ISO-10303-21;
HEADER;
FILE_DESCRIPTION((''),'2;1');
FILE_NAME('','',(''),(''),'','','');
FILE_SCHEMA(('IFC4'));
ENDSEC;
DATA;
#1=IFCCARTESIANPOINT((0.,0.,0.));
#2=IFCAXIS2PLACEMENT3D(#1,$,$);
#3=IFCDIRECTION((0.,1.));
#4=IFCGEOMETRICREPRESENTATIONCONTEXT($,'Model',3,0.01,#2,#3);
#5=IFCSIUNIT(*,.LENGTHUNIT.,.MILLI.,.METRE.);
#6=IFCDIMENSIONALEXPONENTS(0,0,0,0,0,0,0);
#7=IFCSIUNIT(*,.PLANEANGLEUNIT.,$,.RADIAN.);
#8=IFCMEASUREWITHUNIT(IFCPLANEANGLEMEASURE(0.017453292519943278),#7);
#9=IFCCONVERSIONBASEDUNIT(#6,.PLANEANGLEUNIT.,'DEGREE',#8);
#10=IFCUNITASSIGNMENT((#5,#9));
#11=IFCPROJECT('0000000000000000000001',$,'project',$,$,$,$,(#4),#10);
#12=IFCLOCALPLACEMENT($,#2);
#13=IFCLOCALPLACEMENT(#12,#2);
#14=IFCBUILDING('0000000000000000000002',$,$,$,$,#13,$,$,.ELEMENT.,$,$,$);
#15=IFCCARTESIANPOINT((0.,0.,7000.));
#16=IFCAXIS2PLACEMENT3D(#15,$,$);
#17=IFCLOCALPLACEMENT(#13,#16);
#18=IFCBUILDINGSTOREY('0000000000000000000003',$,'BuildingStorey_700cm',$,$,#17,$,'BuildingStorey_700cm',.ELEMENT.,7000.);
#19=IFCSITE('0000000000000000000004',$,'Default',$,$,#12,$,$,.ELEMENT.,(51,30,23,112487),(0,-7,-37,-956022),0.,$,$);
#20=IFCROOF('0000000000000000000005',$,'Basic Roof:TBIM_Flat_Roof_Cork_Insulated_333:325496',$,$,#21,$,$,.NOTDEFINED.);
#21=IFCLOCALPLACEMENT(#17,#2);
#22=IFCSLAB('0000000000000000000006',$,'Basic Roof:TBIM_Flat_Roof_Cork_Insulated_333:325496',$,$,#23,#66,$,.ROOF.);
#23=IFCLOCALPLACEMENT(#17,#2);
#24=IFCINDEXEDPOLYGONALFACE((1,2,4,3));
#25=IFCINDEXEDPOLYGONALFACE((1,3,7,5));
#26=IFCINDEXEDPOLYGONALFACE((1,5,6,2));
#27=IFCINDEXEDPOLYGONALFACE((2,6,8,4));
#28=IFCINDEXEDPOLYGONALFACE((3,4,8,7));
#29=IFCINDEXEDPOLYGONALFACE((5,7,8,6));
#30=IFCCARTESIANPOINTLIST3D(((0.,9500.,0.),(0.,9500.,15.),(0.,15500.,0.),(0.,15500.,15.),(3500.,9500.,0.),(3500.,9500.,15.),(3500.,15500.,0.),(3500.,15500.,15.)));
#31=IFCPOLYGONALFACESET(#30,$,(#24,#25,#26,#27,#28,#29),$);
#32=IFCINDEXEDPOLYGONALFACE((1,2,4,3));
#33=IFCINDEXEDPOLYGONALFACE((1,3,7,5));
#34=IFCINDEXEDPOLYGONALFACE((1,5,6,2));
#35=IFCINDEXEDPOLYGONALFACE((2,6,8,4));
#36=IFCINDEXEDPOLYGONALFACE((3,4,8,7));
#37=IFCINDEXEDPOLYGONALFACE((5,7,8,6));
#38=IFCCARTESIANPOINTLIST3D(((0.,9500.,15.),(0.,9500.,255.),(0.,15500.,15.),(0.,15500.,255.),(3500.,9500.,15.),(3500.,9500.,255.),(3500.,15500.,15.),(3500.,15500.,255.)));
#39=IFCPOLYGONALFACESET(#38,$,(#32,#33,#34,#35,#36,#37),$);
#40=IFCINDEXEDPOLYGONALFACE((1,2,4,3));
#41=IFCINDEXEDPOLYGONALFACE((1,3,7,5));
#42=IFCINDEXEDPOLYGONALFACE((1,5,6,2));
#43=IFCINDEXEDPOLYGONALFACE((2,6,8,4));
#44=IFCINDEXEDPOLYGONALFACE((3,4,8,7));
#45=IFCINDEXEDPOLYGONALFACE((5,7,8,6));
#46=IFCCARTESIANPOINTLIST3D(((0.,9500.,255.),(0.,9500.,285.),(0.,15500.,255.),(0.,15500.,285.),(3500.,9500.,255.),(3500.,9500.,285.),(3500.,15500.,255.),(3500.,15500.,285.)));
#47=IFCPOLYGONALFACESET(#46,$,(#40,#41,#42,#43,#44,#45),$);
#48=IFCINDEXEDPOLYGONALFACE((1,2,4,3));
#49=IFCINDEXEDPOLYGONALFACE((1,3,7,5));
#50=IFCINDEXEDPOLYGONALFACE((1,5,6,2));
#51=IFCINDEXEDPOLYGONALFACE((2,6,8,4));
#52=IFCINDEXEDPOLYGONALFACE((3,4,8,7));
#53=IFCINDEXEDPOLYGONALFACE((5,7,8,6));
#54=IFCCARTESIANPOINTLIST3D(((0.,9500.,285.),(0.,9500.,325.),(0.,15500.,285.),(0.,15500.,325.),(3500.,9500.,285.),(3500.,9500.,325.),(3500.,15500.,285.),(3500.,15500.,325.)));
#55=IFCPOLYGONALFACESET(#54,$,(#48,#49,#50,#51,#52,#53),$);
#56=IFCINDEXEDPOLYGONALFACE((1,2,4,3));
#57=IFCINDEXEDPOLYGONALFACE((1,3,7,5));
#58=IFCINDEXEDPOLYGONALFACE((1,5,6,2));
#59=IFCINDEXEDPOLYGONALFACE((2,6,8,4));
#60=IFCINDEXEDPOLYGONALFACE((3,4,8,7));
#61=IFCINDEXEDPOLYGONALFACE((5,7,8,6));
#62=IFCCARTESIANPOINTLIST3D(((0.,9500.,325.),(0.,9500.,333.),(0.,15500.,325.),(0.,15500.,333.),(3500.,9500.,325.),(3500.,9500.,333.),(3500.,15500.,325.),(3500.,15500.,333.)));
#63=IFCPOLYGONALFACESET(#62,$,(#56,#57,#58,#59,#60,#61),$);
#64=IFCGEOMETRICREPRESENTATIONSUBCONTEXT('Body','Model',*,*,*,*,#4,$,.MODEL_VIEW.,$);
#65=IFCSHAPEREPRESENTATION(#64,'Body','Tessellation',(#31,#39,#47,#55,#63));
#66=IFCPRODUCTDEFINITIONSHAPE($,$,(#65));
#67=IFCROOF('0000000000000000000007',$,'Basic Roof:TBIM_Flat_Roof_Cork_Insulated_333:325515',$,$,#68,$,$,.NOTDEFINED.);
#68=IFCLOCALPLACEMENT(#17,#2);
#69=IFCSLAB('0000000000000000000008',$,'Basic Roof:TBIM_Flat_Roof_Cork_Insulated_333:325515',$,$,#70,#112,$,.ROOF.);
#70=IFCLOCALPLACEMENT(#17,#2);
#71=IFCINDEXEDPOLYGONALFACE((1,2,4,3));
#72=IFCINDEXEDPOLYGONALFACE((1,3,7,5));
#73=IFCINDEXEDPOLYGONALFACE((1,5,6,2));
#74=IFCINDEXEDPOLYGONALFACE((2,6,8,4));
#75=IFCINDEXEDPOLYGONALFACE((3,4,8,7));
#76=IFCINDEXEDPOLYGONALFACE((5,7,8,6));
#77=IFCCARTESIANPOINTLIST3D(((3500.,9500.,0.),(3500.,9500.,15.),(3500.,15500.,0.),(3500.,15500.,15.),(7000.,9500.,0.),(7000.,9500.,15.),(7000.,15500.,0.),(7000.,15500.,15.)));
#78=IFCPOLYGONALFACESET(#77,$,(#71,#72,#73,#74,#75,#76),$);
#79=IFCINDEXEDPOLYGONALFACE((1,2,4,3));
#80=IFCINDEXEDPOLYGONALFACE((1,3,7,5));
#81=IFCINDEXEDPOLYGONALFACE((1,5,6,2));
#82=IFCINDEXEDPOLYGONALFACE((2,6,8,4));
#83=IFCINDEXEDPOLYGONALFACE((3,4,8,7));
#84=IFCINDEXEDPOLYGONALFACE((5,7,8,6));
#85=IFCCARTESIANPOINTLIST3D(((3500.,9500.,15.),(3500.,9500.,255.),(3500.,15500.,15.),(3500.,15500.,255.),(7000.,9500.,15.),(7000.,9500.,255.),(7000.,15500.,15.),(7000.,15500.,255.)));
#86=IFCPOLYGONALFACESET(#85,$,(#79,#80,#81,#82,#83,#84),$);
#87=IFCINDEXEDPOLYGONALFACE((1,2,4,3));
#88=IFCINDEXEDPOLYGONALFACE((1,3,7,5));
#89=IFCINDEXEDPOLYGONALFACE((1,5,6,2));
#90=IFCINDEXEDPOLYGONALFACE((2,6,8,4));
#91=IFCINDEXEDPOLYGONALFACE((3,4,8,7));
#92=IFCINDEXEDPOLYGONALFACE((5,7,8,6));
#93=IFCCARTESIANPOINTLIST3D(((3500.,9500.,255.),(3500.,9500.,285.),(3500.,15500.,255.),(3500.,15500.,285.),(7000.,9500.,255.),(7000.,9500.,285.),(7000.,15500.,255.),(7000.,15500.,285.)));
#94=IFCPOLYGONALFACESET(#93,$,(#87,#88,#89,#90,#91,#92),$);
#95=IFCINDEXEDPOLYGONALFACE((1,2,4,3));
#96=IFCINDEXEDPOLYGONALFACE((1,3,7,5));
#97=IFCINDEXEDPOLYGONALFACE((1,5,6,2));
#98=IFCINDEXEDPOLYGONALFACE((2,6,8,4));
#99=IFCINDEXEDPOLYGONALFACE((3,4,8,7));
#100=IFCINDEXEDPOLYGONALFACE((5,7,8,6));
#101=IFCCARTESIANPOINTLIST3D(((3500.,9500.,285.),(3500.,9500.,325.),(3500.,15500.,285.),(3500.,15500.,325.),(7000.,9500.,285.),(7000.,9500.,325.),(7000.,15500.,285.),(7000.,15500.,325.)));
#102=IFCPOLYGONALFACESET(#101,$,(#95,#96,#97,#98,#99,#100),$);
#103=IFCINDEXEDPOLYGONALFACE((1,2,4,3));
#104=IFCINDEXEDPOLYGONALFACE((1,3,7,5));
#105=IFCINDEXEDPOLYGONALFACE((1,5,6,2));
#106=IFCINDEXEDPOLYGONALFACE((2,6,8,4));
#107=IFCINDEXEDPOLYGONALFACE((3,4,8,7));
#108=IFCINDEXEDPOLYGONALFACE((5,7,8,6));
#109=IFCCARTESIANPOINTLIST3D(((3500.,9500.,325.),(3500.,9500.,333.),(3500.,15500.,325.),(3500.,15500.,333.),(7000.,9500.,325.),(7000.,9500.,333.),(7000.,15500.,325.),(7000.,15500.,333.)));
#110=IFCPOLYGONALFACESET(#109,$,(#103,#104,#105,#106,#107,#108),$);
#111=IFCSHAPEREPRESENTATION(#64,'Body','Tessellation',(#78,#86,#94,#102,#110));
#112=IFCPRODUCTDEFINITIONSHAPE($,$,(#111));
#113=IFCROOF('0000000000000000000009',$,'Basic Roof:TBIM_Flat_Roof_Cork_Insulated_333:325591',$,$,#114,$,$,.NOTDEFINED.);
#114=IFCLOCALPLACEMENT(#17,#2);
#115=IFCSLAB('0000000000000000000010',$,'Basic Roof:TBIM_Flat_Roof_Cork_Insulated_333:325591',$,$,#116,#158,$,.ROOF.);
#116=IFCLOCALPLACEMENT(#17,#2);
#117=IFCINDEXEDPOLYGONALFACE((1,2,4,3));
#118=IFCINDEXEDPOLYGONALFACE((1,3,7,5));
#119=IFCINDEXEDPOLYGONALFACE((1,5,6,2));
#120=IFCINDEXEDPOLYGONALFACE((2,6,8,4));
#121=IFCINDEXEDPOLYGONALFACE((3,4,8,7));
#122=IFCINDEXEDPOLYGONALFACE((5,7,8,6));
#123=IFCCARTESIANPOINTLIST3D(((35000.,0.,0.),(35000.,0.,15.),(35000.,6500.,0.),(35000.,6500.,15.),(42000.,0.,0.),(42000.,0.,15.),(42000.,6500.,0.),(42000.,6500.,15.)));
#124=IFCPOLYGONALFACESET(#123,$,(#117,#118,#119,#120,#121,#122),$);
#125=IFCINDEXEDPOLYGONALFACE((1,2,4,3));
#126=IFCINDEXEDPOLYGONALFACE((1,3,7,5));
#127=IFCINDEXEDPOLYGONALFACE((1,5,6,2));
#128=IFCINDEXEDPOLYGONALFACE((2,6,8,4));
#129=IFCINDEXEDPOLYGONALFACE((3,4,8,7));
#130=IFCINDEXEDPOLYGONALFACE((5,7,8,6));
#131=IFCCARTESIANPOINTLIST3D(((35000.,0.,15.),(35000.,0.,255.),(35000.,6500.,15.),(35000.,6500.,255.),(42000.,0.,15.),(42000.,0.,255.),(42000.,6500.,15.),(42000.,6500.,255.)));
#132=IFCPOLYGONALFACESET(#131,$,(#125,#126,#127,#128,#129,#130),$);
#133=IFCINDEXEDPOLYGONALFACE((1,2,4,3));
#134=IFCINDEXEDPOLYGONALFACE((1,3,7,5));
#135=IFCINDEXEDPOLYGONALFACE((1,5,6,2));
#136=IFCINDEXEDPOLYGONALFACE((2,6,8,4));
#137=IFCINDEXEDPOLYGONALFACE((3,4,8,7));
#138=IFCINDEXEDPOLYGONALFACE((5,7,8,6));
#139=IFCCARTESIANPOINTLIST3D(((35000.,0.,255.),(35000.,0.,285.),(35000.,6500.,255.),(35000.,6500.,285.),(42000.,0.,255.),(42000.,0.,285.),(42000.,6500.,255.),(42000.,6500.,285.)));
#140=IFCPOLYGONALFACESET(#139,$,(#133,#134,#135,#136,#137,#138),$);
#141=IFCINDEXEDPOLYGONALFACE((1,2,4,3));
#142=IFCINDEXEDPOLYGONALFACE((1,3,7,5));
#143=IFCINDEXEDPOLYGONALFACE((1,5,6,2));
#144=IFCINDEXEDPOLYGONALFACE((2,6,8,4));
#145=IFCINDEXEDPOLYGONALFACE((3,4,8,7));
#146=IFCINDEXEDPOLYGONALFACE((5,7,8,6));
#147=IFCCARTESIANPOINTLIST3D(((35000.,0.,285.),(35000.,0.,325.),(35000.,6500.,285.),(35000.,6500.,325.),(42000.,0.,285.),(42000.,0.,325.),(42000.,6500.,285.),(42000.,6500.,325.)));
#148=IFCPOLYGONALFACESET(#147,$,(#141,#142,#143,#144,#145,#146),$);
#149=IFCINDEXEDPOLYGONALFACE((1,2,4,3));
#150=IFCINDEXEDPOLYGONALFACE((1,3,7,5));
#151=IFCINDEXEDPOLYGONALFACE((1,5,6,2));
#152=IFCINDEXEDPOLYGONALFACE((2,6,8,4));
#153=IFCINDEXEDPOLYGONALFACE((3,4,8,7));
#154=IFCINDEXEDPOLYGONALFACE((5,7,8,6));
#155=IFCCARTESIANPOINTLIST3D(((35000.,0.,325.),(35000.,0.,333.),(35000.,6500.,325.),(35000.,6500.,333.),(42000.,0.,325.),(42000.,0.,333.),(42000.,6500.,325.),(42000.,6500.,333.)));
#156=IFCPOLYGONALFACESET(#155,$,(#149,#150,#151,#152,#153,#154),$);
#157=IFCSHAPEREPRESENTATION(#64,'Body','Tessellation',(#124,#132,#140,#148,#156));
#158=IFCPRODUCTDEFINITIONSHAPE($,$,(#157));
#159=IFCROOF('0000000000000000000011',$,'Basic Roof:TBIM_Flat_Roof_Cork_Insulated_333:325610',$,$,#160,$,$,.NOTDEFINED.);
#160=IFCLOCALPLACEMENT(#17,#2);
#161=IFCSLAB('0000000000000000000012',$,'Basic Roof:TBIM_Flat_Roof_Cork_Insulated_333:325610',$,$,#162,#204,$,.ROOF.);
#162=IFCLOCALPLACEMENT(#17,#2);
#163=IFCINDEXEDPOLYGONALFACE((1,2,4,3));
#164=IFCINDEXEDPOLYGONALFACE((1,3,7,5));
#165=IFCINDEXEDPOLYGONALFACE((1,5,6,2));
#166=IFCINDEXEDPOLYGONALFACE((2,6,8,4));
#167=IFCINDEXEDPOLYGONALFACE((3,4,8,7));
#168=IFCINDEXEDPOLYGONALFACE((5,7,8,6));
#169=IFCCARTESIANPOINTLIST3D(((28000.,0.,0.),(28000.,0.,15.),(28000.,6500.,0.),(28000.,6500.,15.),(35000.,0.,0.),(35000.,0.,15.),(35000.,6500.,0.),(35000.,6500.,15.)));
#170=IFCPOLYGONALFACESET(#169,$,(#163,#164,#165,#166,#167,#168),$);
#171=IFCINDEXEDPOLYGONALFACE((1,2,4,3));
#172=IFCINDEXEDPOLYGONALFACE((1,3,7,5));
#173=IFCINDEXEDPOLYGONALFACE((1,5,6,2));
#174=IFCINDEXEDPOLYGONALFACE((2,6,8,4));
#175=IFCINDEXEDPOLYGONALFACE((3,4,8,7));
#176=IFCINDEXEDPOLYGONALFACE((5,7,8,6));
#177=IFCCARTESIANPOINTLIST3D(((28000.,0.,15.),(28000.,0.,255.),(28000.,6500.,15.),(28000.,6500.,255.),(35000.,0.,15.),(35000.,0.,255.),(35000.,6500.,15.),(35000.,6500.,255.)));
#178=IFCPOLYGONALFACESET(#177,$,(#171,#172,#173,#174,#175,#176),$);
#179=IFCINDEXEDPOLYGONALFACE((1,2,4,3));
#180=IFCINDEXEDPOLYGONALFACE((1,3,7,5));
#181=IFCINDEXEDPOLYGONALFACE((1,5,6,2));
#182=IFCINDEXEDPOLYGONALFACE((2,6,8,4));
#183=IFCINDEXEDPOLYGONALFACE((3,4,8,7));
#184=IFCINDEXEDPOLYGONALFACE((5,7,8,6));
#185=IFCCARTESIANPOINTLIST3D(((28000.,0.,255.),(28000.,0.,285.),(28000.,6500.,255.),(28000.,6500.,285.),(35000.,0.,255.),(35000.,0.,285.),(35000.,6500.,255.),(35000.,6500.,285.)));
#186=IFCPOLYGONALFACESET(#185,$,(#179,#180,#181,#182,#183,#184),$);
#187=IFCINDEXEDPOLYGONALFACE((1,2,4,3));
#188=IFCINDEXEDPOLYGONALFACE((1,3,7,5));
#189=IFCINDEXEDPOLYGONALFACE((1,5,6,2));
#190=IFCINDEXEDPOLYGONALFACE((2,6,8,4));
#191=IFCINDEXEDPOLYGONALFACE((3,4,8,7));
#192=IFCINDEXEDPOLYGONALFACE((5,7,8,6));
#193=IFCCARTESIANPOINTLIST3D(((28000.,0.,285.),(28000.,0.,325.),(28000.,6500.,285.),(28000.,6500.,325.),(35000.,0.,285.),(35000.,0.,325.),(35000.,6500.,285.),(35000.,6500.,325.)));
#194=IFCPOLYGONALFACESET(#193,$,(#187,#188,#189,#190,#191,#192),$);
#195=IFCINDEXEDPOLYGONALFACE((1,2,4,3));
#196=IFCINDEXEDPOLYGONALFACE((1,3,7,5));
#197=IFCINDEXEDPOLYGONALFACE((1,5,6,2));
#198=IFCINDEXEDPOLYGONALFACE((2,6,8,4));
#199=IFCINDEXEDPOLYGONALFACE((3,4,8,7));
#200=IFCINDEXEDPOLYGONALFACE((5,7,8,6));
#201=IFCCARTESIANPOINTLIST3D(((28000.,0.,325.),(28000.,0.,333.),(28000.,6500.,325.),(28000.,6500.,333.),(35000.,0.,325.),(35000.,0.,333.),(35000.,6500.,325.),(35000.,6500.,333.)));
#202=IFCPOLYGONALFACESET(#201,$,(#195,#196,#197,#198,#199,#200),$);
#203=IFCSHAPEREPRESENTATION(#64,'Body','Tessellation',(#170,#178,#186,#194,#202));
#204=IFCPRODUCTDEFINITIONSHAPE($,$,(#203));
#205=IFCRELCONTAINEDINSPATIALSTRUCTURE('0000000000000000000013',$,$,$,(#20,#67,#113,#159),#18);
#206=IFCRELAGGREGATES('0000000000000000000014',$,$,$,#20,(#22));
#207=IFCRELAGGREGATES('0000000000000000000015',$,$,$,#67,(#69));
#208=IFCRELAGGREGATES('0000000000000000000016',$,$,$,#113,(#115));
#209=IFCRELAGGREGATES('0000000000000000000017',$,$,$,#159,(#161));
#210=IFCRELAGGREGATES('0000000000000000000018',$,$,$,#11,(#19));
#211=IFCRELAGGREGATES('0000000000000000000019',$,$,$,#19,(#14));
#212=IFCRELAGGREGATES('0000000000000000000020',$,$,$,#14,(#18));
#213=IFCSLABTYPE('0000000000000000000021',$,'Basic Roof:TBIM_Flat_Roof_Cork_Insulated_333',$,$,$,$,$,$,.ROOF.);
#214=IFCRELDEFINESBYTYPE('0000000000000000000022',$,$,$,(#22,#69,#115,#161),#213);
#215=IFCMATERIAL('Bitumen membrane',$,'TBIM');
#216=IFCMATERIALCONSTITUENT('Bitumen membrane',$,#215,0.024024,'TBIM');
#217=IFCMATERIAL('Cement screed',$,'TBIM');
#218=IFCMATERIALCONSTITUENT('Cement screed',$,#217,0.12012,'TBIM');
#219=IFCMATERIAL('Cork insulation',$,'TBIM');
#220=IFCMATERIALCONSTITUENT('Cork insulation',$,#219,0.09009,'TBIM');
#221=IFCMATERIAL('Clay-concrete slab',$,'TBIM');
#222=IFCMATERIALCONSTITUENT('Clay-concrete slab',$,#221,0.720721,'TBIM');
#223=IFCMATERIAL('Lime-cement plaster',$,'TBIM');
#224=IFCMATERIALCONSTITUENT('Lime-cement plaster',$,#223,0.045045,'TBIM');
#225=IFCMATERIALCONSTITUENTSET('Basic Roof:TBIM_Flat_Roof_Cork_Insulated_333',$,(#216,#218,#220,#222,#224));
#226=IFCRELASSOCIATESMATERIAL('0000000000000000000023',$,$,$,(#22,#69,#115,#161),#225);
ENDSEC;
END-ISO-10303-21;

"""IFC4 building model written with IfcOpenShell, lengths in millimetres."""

from ifc_helpers import new_model, entity, si_unit, converted_unit, direction, frame, origin, place, context, subcontext, project, spatial, indexed_curve, outline, extrude, material, constituent, constituent_set, type_object, element, aggregate, save


model = new_model("IFC4")

# Units and contexts
model_context = context("Model", 3, precision=0.01, world=origin(), true_north=direction((0.0, 1.0)))
body_context = subcontext(model_context, "Body", "Model", "MODEL_VIEW")
ifc_project = project(units=[si_unit("LENGTHUNIT", "METRE", prefix="MILLI"), converted_unit("PLANEANGLEUNIT", "DEGREE", entity("IfcPlaneAngleMeasure", 0.017453292519943278), si_unit("PLANEANGLEUNIT", "RADIAN"), dimensions=[0, 0, 0, 0, 0, 0, 0])], contexts=[model_context])

# Site, building, storey
site_placement = place(None, origin())
site = spatial("IfcSite", under=ifc_project, at=site_placement, Name="Default", CompositionType="ELEMENT", RefLatitude=(51, 30, 23, 112487), RefLongitude=(0, -7, -37, -956022), RefElevation=0.0)
building_placement = place(site_placement, origin())
building = spatial("IfcBuilding", under=site, at=building_placement, CompositionType="ELEMENT")
storey_placement = place(building_placement, frame((0.0, 0.0, 7000.0)))
storey = spatial("IfcBuildingStorey", under=building, at=storey_placement, Name="BuildingStorey_700cm", LongName="BuildingStorey_700cm", CompositionType="ELEMENT", Elevation=7000.0)

# Roofs, slabs
ifc_material_1 = material(Name="Bitumen membrane", Category="TBIM")
ifc_constituent_1 = constituent(ifc_material_1, Name="Bitumen membrane", Category="TBIM", fraction=0.024024)
ifc_material_2 = material(Name="Cement screed", Category="TBIM")
ifc_constituent_2 = constituent(ifc_material_2, Name="Cement screed", Category="TBIM", fraction=0.12012)
ifc_material_3 = material(Name="Cork insulation", Category="TBIM")
ifc_constituent_3 = constituent(ifc_material_3, Name="Cork insulation", Category="TBIM", fraction=0.09009)
ifc_material_4 = material(Name="Clay-concrete slab", Category="TBIM")
ifc_constituent_4 = constituent(ifc_material_4, Name="Clay-concrete slab", Category="TBIM", fraction=0.720721)
ifc_material_5 = material(Name="Lime-cement plaster", Category="TBIM")
ifc_constituent_5 = constituent(ifc_material_5, Name="Lime-cement plaster", Category="TBIM", fraction=0.045045)
ifc_constituent_set = constituent_set(constituents=[ifc_constituent_1, ifc_constituent_2, ifc_constituent_3, ifc_constituent_4, ifc_constituent_5], Name="Basic Roof:TBIM_Flat_Roof_Cork_Insulated_333")
slab_type = type_object("IfcSlabType", Name="Basic Roof:TBIM_Flat_Roof_Cork_Insulated_333", PredefinedType="ROOF")
roof_1_placement = place(storey_placement, frame((0.0, 9500.0, 0.0)))
roof_1 = element("IfcRoof", 1, at=roof_1_placement, inside=storey, Name="Basic Roof:TBIM_Flat_Roof_Cork_Insulated_333:325496", PredefinedType="NOTDEFINED")
slab_1_placement = place(roof_1_placement, origin())
slab_1 = element("IfcSlab", 2, at=slab_1_placement, type_object=slab_type, material=ifc_constituent_set, Name="Basic Roof:TBIM_Flat_Roof_Cork_Insulated_333:325496", PredefinedType="ROOF", context=body_context, shape_type="SweptSolid", body=[
    extrude(outline(indexed_curve([(-1750.0, 3000.0), (-1750.0, -3000.0), (1750.0, -3000.0), (1750.0, 3000.0), (-1750.0, 3000.0)], self_intersect=False)), frame((1750.0, 3000.0, 0.0)), (0.0, 0.0, 1.0), 15.0),
    extrude(outline(indexed_curve([(-1750.0, 3000.0), (-1750.0, -3000.0), (1750.0, -3000.0), (1750.0, 3000.0), (-1750.0, 3000.0)], self_intersect=False)), frame((1750.0, 3000.0, 15.0)), (0.0, 0.0, 1.0), 240.0),
    extrude(outline(indexed_curve([(-1750.0, 3000.0), (-1750.0, -3000.0), (1750.0, -3000.0), (1750.0, 3000.0), (-1750.0, 3000.0)], self_intersect=False)), frame((1750.0, 3000.0, 255.0)), (0.0, 0.0, 1.0), 30.0),
    extrude(outline(indexed_curve([(-1750.0, 3000.0), (-1750.0, -3000.0), (1750.0, -3000.0), (1750.0, 3000.0), (-1750.0, 3000.0)], self_intersect=False)), frame((1750.0, 3000.0, 285.0)), (0.0, 0.0, 1.0), 40.0),
    extrude(outline(indexed_curve([(-1750.0, 3000.0), (-1750.0, -3000.0), (1750.0, -3000.0), (1750.0, 3000.0), (-1750.0, 3000.0)], self_intersect=False)), frame((1750.0, 3000.0, 325.0)), (0.0, 0.0, 1.0), 8.0),
])
aggregate(roof_1, [slab_1])
roof_2_placement = place(storey_placement, frame((3500.0, 9500.0, 0.0)))
roof_2 = element("IfcRoof", 3, at=roof_2_placement, inside=storey, Name="Basic Roof:TBIM_Flat_Roof_Cork_Insulated_333:325515", PredefinedType="NOTDEFINED")
slab_2_placement = place(roof_2_placement, origin())
slab_2 = element("IfcSlab", 4, at=slab_2_placement, type_object=slab_type, material=ifc_constituent_set, Name="Basic Roof:TBIM_Flat_Roof_Cork_Insulated_333:325515", PredefinedType="ROOF", context=body_context, shape_type="SweptSolid", body=[
    extrude(outline(indexed_curve([(-1750.0, 3000.0), (-1750.0, -3000.0), (1750.0, -3000.0), (1750.0, 3000.0), (-1750.0, 3000.0)], self_intersect=False)), frame((1750.0, 3000.0, 0.0)), (0.0, 0.0, 1.0), 15.0),
    extrude(outline(indexed_curve([(-1750.0, 3000.0), (-1750.0, -3000.0), (1750.0, -3000.0), (1750.0, 3000.0), (-1750.0, 3000.0)], self_intersect=False)), frame((1750.0, 3000.0, 15.0)), (0.0, 0.0, 1.0), 240.0),
    extrude(outline(indexed_curve([(-1750.0, 3000.0), (-1750.0, -3000.0), (1750.0, -3000.0), (1750.0, 3000.0), (-1750.0, 3000.0)], self_intersect=False)), frame((1750.0, 3000.0, 255.0)), (0.0, 0.0, 1.0), 30.0),
    extrude(outline(indexed_curve([(-1750.0, 3000.0), (-1750.0, -3000.0), (1750.0, -3000.0), (1750.0, 3000.0), (-1750.0, 3000.0)], self_intersect=False)), frame((1750.0, 3000.0, 285.0)), (0.0, 0.0, 1.0), 40.0),
    extrude(outline(indexed_curve([(-1750.0, 3000.0), (-1750.0, -3000.0), (1750.0, -3000.0), (1750.0, 3000.0), (-1750.0, 3000.0)], self_intersect=False)), frame((1750.0, 3000.0, 325.0)), (0.0, 0.0, 1.0), 8.0),
])
aggregate(roof_2, [slab_2])
roof_3_placement = place(storey_placement, frame((35000.0, 0.0, 0.0)))
roof_3 = element("IfcRoof", 5, at=roof_3_placement, inside=storey, Name="Basic Roof:TBIM_Flat_Roof_Cork_Insulated_333:325591", PredefinedType="NOTDEFINED")
slab_3_placement = place(roof_3_placement, origin())
slab_3 = element("IfcSlab", 6, at=slab_3_placement, type_object=slab_type, material=ifc_constituent_set, Name="Basic Roof:TBIM_Flat_Roof_Cork_Insulated_333:325591", PredefinedType="ROOF", context=body_context, shape_type="SweptSolid", body=[
    extrude(outline(indexed_curve([(-3500.0, 3250.0), (-3500.0, -3250.0), (3500.0, -3250.0), (3500.0, 3250.0), (-3500.0, 3250.0)], self_intersect=False)), frame((3500.0, 3250.0, 0.0)), (0.0, 0.0, 1.0), 15.0),
    extrude(outline(indexed_curve([(-3500.0, 3250.0), (-3500.0, -3250.0), (3500.0, -3250.0), (3500.0, 3250.0), (-3500.0, 3250.0)], self_intersect=False)), frame((3500.0, 3250.0, 15.0)), (0.0, 0.0, 1.0), 240.0),
    extrude(outline(indexed_curve([(-3500.0, 3250.0), (-3500.0, -3250.0), (3500.0, -3250.0), (3500.0, 3250.0), (-3500.0, 3250.0)], self_intersect=False)), frame((3500.0, 3250.0, 255.0)), (0.0, 0.0, 1.0), 30.0),
    extrude(outline(indexed_curve([(-3500.0, 3250.0), (-3500.0, -3250.0), (3500.0, -3250.0), (3500.0, 3250.0), (-3500.0, 3250.0)], self_intersect=False)), frame((3500.0, 3250.0, 285.0)), (0.0, 0.0, 1.0), 40.0),
    extrude(outline(indexed_curve([(-3500.0, 3250.0), (-3500.0, -3250.0), (3500.0, -3250.0), (3500.0, 3250.0), (-3500.0, 3250.0)], self_intersect=False)), frame((3500.0, 3250.0, 325.0)), (0.0, 0.0, 1.0), 8.0),
])
aggregate(roof_3, [slab_3])
roof_4_placement = place(storey_placement, frame((28000.0, 0.0, 0.0)))
roof_4 = element("IfcRoof", 7, at=roof_4_placement, inside=storey, Name="Basic Roof:TBIM_Flat_Roof_Cork_Insulated_333:325610", PredefinedType="NOTDEFINED")
slab_4_placement = place(roof_4_placement, origin())
slab_4 = element("IfcSlab", 8, at=slab_4_placement, type_object=slab_type, material=ifc_constituent_set, Name="Basic Roof:TBIM_Flat_Roof_Cork_Insulated_333:325610", PredefinedType="ROOF", context=body_context, shape_type="SweptSolid", body=[
    extrude(outline(indexed_curve([(-3500.0, 3250.0), (-3500.0, -3250.0), (3500.0, -3250.0), (3500.0, 3250.0), (-3500.0, 3250.0)], self_intersect=False)), frame((3500.0, 3250.0, 0.0)), (0.0, 0.0, 1.0), 15.0),
    extrude(outline(indexed_curve([(-3500.0, 3250.0), (-3500.0, -3250.0), (3500.0, -3250.0), (3500.0, 3250.0), (-3500.0, 3250.0)], self_intersect=False)), frame((3500.0, 3250.0, 15.0)), (0.0, 0.0, 1.0), 240.0),
    extrude(outline(indexed_curve([(-3500.0, 3250.0), (-3500.0, -3250.0), (3500.0, -3250.0), (3500.0, 3250.0), (-3500.0, 3250.0)], self_intersect=False)), frame((3500.0, 3250.0, 255.0)), (0.0, 0.0, 1.0), 30.0),
    extrude(outline(indexed_curve([(-3500.0, 3250.0), (-3500.0, -3250.0), (3500.0, -3250.0), (3500.0, 3250.0), (-3500.0, 3250.0)], self_intersect=False)), frame((3500.0, 3250.0, 285.0)), (0.0, 0.0, 1.0), 40.0),
    extrude(outline(indexed_curve([(-3500.0, 3250.0), (-3500.0, -3250.0), (3500.0, -3250.0), (3500.0, 3250.0), (-3500.0, 3250.0)], self_intersect=False)), frame((3500.0, 3250.0, 325.0)), (0.0, 0.0, 1.0), 8.0),
])
aggregate(roof_4, [slab_4])

save(model, "model.ifc")
